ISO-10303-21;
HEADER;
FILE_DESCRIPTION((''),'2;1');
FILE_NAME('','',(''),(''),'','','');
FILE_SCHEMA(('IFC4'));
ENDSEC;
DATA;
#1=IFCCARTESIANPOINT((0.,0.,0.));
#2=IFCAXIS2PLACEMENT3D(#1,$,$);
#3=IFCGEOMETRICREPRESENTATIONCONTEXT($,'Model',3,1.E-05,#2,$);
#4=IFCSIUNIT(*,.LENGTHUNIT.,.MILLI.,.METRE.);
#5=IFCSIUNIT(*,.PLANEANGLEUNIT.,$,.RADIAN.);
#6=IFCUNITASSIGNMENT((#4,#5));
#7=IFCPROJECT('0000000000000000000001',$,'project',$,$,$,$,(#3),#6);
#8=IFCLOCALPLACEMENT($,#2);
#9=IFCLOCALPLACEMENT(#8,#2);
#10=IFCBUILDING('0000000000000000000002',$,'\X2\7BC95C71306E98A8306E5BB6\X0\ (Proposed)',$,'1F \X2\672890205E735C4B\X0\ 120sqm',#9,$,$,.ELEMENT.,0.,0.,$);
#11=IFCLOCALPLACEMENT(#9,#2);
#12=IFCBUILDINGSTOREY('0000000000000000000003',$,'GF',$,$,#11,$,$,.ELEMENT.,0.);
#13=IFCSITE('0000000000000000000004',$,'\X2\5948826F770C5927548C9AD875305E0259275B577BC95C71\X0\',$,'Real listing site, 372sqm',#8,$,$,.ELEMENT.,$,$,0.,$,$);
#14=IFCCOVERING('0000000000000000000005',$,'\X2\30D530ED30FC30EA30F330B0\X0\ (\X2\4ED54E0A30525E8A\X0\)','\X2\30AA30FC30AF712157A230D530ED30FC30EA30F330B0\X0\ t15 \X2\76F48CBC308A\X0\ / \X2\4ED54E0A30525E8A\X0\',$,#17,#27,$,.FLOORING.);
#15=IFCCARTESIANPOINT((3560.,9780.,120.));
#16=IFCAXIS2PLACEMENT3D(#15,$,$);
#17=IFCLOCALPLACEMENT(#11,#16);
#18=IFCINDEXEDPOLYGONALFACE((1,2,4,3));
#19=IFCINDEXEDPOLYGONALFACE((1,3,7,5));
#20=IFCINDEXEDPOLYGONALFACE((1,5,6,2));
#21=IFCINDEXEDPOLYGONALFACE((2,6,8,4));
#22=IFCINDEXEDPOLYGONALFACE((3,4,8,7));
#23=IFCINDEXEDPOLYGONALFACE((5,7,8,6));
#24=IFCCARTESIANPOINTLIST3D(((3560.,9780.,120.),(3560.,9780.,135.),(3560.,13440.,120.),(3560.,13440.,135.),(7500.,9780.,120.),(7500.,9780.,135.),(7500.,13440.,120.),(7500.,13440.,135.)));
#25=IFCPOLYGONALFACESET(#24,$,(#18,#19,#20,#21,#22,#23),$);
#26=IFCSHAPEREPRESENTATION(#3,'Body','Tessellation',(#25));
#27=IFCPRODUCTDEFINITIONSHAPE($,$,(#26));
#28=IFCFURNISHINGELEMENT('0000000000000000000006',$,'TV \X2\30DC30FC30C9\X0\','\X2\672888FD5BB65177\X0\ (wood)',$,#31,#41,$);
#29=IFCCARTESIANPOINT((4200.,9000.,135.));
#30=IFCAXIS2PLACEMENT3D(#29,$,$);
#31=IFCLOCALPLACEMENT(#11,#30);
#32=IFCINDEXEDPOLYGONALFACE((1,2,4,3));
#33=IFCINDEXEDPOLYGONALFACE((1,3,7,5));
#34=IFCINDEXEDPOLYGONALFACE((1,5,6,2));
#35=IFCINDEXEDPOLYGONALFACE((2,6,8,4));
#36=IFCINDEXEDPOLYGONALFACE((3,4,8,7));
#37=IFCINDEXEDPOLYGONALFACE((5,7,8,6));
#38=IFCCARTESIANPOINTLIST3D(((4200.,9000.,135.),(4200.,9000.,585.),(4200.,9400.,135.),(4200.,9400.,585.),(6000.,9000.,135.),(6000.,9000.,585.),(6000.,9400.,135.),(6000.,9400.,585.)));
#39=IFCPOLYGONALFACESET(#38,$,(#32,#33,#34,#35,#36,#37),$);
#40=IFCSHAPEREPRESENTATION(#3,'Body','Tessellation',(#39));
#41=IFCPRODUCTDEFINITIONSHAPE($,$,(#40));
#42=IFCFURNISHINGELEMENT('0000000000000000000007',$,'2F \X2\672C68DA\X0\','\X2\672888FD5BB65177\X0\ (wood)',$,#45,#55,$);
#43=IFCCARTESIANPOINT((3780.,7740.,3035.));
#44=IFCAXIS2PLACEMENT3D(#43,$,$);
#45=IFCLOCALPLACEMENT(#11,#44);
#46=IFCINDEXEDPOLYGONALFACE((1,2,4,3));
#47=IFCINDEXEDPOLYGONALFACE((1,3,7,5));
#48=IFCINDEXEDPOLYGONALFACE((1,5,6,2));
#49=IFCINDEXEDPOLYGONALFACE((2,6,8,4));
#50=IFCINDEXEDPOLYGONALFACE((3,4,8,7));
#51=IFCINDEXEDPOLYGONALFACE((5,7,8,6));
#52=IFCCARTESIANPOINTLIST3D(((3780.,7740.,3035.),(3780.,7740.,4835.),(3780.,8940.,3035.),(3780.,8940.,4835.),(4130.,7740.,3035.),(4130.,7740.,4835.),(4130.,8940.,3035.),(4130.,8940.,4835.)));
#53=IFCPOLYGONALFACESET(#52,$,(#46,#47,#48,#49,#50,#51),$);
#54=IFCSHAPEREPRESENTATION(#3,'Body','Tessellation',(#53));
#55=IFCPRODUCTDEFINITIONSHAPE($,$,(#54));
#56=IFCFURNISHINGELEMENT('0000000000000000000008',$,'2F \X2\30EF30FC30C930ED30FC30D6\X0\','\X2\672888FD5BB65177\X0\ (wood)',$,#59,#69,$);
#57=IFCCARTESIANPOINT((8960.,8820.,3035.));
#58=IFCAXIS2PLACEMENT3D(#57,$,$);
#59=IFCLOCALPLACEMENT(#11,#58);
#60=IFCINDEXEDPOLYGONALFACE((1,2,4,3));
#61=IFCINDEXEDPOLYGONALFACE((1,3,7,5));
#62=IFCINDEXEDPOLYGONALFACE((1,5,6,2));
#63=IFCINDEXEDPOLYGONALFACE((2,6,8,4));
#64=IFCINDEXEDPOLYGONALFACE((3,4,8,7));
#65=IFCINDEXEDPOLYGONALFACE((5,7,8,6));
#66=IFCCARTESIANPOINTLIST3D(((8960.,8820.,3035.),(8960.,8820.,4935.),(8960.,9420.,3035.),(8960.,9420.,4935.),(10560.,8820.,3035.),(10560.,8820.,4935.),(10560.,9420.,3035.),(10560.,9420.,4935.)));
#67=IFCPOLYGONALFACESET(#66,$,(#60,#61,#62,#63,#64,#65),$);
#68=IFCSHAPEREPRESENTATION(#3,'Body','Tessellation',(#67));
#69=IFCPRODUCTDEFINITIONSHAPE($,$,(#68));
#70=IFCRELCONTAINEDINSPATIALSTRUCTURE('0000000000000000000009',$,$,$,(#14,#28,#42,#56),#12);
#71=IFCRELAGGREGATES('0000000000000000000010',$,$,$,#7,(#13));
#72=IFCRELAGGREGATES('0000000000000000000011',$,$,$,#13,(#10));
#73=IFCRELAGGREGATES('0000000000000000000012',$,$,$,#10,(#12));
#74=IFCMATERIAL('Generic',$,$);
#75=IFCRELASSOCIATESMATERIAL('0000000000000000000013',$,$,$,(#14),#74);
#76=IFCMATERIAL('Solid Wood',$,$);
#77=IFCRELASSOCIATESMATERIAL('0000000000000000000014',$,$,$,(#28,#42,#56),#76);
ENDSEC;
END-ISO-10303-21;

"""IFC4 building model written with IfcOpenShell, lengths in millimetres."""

from ifc_helpers import new_model, si_unit, frame, frame_2d, origin, place, context, project, spatial, rectangle, extrude, material, element, save


model = new_model("IFC4")

# Units and contexts
model_context = context("Model", 3, precision=1e-05, world=origin())
ifc_project = project(units=[si_unit("LENGTHUNIT", "METRE", prefix="MILLI"), si_unit("PLANEANGLEUNIT", "RADIAN")], contexts=[model_context])

# Site, building, storey
site_placement = place(None, origin())
site = spatial("IfcSite", under=ifc_project, at=site_placement, Name="奈良県大和高田市大字築山", ObjectType="Real listing site, 372sqm", CompositionType="ELEMENT", RefElevation=0.0)
building_placement = place(site_placement, origin())
building = spatial("IfcBuilding", under=site, at=building_placement, Name="築山の風の家 (Proposed)", ObjectType="1F 木造平屋 120sqm", CompositionType="ELEMENT", ElevationOfRefHeight=0.0, ElevationOfTerrain=0.0)
storey_placement = place(building_placement, origin())
storey = spatial("IfcBuildingStorey", under=building, at=storey_placement, Name="GF", CompositionType="ELEMENT", Elevation=0.0)

# Shared definitions
ifc_material_1 = material(Name="Solid Wood")

# Shared definitions
ifc_material_2 = material(Name="Generic")

# Covering
covering_placement = place(storey_placement, frame((3560.0, 9780.0, 120.0)))
element("IfcCovering", 1, at=covering_placement, inside=storey, material=ifc_material_2, Name="フローリング (仕上げ床)", Description="オーク無垢フローリング t15 直貼り / 仕上げ床", PredefinedType="FLOORING", context=model_context, shape_type="SweptSolid", body=[
    extrude(rectangle(XDim=3940.0, YDim=3660.0, at=frame_2d((1970.0, 1830.0))), frame((3560.0, 9780.0, 120.0)), (0.0, 0.0, 1.0), 15.0),
])

# Furnishing elements
furnishing_1_placement = place(storey_placement, frame((4200.0, 9000.0, 135.0)))
element("IfcFurnishingElement", 2, at=furnishing_1_placement, inside=storey, material=ifc_material_1, Name="TV ボード", Description="木製家具 (wood)", context=model_context, shape_type="SweptSolid", body=[
    extrude(rectangle(XDim=1800.0, YDim=400.0, at=frame_2d((900.0, 200.0))), frame((4200.0, 9000.0, 135.0)), (0.0, 0.0, 1.0), 450.0),
])
furnishing_2_placement = place(storey_placement, frame((3780.0, 7740.0, 3035.0)))
element("IfcFurnishingElement", 3, at=furnishing_2_placement, inside=storey, material=ifc_material_1, Name="2F 本棚", Description="木製家具 (wood)", context=model_context, shape_type="SweptSolid", body=[
    extrude(rectangle(XDim=350.0, YDim=1200.0, at=frame_2d((175.0, 600.0))), frame((3780.0, 7740.0, 3035.0)), (0.0, 0.0, 1.0), 1800.0),
])
furnishing_3_placement = place(storey_placement, frame((8960.0, 8820.0, 3035.0)))
element("IfcFurnishingElement", 4, at=furnishing_3_placement, inside=storey, material=ifc_material_1, Name="2F ワードローブ", Description="木製家具 (wood)", context=model_context, shape_type="SweptSolid", body=[
    extrude(rectangle(XDim=1600.0, YDim=600.0, at=frame_2d((800.0, 300.0))), frame((8960.0, 8820.0, 3035.0)), (0.0, 0.0, 1.0), 1900.0),
])

save(model, "model.ifc")
